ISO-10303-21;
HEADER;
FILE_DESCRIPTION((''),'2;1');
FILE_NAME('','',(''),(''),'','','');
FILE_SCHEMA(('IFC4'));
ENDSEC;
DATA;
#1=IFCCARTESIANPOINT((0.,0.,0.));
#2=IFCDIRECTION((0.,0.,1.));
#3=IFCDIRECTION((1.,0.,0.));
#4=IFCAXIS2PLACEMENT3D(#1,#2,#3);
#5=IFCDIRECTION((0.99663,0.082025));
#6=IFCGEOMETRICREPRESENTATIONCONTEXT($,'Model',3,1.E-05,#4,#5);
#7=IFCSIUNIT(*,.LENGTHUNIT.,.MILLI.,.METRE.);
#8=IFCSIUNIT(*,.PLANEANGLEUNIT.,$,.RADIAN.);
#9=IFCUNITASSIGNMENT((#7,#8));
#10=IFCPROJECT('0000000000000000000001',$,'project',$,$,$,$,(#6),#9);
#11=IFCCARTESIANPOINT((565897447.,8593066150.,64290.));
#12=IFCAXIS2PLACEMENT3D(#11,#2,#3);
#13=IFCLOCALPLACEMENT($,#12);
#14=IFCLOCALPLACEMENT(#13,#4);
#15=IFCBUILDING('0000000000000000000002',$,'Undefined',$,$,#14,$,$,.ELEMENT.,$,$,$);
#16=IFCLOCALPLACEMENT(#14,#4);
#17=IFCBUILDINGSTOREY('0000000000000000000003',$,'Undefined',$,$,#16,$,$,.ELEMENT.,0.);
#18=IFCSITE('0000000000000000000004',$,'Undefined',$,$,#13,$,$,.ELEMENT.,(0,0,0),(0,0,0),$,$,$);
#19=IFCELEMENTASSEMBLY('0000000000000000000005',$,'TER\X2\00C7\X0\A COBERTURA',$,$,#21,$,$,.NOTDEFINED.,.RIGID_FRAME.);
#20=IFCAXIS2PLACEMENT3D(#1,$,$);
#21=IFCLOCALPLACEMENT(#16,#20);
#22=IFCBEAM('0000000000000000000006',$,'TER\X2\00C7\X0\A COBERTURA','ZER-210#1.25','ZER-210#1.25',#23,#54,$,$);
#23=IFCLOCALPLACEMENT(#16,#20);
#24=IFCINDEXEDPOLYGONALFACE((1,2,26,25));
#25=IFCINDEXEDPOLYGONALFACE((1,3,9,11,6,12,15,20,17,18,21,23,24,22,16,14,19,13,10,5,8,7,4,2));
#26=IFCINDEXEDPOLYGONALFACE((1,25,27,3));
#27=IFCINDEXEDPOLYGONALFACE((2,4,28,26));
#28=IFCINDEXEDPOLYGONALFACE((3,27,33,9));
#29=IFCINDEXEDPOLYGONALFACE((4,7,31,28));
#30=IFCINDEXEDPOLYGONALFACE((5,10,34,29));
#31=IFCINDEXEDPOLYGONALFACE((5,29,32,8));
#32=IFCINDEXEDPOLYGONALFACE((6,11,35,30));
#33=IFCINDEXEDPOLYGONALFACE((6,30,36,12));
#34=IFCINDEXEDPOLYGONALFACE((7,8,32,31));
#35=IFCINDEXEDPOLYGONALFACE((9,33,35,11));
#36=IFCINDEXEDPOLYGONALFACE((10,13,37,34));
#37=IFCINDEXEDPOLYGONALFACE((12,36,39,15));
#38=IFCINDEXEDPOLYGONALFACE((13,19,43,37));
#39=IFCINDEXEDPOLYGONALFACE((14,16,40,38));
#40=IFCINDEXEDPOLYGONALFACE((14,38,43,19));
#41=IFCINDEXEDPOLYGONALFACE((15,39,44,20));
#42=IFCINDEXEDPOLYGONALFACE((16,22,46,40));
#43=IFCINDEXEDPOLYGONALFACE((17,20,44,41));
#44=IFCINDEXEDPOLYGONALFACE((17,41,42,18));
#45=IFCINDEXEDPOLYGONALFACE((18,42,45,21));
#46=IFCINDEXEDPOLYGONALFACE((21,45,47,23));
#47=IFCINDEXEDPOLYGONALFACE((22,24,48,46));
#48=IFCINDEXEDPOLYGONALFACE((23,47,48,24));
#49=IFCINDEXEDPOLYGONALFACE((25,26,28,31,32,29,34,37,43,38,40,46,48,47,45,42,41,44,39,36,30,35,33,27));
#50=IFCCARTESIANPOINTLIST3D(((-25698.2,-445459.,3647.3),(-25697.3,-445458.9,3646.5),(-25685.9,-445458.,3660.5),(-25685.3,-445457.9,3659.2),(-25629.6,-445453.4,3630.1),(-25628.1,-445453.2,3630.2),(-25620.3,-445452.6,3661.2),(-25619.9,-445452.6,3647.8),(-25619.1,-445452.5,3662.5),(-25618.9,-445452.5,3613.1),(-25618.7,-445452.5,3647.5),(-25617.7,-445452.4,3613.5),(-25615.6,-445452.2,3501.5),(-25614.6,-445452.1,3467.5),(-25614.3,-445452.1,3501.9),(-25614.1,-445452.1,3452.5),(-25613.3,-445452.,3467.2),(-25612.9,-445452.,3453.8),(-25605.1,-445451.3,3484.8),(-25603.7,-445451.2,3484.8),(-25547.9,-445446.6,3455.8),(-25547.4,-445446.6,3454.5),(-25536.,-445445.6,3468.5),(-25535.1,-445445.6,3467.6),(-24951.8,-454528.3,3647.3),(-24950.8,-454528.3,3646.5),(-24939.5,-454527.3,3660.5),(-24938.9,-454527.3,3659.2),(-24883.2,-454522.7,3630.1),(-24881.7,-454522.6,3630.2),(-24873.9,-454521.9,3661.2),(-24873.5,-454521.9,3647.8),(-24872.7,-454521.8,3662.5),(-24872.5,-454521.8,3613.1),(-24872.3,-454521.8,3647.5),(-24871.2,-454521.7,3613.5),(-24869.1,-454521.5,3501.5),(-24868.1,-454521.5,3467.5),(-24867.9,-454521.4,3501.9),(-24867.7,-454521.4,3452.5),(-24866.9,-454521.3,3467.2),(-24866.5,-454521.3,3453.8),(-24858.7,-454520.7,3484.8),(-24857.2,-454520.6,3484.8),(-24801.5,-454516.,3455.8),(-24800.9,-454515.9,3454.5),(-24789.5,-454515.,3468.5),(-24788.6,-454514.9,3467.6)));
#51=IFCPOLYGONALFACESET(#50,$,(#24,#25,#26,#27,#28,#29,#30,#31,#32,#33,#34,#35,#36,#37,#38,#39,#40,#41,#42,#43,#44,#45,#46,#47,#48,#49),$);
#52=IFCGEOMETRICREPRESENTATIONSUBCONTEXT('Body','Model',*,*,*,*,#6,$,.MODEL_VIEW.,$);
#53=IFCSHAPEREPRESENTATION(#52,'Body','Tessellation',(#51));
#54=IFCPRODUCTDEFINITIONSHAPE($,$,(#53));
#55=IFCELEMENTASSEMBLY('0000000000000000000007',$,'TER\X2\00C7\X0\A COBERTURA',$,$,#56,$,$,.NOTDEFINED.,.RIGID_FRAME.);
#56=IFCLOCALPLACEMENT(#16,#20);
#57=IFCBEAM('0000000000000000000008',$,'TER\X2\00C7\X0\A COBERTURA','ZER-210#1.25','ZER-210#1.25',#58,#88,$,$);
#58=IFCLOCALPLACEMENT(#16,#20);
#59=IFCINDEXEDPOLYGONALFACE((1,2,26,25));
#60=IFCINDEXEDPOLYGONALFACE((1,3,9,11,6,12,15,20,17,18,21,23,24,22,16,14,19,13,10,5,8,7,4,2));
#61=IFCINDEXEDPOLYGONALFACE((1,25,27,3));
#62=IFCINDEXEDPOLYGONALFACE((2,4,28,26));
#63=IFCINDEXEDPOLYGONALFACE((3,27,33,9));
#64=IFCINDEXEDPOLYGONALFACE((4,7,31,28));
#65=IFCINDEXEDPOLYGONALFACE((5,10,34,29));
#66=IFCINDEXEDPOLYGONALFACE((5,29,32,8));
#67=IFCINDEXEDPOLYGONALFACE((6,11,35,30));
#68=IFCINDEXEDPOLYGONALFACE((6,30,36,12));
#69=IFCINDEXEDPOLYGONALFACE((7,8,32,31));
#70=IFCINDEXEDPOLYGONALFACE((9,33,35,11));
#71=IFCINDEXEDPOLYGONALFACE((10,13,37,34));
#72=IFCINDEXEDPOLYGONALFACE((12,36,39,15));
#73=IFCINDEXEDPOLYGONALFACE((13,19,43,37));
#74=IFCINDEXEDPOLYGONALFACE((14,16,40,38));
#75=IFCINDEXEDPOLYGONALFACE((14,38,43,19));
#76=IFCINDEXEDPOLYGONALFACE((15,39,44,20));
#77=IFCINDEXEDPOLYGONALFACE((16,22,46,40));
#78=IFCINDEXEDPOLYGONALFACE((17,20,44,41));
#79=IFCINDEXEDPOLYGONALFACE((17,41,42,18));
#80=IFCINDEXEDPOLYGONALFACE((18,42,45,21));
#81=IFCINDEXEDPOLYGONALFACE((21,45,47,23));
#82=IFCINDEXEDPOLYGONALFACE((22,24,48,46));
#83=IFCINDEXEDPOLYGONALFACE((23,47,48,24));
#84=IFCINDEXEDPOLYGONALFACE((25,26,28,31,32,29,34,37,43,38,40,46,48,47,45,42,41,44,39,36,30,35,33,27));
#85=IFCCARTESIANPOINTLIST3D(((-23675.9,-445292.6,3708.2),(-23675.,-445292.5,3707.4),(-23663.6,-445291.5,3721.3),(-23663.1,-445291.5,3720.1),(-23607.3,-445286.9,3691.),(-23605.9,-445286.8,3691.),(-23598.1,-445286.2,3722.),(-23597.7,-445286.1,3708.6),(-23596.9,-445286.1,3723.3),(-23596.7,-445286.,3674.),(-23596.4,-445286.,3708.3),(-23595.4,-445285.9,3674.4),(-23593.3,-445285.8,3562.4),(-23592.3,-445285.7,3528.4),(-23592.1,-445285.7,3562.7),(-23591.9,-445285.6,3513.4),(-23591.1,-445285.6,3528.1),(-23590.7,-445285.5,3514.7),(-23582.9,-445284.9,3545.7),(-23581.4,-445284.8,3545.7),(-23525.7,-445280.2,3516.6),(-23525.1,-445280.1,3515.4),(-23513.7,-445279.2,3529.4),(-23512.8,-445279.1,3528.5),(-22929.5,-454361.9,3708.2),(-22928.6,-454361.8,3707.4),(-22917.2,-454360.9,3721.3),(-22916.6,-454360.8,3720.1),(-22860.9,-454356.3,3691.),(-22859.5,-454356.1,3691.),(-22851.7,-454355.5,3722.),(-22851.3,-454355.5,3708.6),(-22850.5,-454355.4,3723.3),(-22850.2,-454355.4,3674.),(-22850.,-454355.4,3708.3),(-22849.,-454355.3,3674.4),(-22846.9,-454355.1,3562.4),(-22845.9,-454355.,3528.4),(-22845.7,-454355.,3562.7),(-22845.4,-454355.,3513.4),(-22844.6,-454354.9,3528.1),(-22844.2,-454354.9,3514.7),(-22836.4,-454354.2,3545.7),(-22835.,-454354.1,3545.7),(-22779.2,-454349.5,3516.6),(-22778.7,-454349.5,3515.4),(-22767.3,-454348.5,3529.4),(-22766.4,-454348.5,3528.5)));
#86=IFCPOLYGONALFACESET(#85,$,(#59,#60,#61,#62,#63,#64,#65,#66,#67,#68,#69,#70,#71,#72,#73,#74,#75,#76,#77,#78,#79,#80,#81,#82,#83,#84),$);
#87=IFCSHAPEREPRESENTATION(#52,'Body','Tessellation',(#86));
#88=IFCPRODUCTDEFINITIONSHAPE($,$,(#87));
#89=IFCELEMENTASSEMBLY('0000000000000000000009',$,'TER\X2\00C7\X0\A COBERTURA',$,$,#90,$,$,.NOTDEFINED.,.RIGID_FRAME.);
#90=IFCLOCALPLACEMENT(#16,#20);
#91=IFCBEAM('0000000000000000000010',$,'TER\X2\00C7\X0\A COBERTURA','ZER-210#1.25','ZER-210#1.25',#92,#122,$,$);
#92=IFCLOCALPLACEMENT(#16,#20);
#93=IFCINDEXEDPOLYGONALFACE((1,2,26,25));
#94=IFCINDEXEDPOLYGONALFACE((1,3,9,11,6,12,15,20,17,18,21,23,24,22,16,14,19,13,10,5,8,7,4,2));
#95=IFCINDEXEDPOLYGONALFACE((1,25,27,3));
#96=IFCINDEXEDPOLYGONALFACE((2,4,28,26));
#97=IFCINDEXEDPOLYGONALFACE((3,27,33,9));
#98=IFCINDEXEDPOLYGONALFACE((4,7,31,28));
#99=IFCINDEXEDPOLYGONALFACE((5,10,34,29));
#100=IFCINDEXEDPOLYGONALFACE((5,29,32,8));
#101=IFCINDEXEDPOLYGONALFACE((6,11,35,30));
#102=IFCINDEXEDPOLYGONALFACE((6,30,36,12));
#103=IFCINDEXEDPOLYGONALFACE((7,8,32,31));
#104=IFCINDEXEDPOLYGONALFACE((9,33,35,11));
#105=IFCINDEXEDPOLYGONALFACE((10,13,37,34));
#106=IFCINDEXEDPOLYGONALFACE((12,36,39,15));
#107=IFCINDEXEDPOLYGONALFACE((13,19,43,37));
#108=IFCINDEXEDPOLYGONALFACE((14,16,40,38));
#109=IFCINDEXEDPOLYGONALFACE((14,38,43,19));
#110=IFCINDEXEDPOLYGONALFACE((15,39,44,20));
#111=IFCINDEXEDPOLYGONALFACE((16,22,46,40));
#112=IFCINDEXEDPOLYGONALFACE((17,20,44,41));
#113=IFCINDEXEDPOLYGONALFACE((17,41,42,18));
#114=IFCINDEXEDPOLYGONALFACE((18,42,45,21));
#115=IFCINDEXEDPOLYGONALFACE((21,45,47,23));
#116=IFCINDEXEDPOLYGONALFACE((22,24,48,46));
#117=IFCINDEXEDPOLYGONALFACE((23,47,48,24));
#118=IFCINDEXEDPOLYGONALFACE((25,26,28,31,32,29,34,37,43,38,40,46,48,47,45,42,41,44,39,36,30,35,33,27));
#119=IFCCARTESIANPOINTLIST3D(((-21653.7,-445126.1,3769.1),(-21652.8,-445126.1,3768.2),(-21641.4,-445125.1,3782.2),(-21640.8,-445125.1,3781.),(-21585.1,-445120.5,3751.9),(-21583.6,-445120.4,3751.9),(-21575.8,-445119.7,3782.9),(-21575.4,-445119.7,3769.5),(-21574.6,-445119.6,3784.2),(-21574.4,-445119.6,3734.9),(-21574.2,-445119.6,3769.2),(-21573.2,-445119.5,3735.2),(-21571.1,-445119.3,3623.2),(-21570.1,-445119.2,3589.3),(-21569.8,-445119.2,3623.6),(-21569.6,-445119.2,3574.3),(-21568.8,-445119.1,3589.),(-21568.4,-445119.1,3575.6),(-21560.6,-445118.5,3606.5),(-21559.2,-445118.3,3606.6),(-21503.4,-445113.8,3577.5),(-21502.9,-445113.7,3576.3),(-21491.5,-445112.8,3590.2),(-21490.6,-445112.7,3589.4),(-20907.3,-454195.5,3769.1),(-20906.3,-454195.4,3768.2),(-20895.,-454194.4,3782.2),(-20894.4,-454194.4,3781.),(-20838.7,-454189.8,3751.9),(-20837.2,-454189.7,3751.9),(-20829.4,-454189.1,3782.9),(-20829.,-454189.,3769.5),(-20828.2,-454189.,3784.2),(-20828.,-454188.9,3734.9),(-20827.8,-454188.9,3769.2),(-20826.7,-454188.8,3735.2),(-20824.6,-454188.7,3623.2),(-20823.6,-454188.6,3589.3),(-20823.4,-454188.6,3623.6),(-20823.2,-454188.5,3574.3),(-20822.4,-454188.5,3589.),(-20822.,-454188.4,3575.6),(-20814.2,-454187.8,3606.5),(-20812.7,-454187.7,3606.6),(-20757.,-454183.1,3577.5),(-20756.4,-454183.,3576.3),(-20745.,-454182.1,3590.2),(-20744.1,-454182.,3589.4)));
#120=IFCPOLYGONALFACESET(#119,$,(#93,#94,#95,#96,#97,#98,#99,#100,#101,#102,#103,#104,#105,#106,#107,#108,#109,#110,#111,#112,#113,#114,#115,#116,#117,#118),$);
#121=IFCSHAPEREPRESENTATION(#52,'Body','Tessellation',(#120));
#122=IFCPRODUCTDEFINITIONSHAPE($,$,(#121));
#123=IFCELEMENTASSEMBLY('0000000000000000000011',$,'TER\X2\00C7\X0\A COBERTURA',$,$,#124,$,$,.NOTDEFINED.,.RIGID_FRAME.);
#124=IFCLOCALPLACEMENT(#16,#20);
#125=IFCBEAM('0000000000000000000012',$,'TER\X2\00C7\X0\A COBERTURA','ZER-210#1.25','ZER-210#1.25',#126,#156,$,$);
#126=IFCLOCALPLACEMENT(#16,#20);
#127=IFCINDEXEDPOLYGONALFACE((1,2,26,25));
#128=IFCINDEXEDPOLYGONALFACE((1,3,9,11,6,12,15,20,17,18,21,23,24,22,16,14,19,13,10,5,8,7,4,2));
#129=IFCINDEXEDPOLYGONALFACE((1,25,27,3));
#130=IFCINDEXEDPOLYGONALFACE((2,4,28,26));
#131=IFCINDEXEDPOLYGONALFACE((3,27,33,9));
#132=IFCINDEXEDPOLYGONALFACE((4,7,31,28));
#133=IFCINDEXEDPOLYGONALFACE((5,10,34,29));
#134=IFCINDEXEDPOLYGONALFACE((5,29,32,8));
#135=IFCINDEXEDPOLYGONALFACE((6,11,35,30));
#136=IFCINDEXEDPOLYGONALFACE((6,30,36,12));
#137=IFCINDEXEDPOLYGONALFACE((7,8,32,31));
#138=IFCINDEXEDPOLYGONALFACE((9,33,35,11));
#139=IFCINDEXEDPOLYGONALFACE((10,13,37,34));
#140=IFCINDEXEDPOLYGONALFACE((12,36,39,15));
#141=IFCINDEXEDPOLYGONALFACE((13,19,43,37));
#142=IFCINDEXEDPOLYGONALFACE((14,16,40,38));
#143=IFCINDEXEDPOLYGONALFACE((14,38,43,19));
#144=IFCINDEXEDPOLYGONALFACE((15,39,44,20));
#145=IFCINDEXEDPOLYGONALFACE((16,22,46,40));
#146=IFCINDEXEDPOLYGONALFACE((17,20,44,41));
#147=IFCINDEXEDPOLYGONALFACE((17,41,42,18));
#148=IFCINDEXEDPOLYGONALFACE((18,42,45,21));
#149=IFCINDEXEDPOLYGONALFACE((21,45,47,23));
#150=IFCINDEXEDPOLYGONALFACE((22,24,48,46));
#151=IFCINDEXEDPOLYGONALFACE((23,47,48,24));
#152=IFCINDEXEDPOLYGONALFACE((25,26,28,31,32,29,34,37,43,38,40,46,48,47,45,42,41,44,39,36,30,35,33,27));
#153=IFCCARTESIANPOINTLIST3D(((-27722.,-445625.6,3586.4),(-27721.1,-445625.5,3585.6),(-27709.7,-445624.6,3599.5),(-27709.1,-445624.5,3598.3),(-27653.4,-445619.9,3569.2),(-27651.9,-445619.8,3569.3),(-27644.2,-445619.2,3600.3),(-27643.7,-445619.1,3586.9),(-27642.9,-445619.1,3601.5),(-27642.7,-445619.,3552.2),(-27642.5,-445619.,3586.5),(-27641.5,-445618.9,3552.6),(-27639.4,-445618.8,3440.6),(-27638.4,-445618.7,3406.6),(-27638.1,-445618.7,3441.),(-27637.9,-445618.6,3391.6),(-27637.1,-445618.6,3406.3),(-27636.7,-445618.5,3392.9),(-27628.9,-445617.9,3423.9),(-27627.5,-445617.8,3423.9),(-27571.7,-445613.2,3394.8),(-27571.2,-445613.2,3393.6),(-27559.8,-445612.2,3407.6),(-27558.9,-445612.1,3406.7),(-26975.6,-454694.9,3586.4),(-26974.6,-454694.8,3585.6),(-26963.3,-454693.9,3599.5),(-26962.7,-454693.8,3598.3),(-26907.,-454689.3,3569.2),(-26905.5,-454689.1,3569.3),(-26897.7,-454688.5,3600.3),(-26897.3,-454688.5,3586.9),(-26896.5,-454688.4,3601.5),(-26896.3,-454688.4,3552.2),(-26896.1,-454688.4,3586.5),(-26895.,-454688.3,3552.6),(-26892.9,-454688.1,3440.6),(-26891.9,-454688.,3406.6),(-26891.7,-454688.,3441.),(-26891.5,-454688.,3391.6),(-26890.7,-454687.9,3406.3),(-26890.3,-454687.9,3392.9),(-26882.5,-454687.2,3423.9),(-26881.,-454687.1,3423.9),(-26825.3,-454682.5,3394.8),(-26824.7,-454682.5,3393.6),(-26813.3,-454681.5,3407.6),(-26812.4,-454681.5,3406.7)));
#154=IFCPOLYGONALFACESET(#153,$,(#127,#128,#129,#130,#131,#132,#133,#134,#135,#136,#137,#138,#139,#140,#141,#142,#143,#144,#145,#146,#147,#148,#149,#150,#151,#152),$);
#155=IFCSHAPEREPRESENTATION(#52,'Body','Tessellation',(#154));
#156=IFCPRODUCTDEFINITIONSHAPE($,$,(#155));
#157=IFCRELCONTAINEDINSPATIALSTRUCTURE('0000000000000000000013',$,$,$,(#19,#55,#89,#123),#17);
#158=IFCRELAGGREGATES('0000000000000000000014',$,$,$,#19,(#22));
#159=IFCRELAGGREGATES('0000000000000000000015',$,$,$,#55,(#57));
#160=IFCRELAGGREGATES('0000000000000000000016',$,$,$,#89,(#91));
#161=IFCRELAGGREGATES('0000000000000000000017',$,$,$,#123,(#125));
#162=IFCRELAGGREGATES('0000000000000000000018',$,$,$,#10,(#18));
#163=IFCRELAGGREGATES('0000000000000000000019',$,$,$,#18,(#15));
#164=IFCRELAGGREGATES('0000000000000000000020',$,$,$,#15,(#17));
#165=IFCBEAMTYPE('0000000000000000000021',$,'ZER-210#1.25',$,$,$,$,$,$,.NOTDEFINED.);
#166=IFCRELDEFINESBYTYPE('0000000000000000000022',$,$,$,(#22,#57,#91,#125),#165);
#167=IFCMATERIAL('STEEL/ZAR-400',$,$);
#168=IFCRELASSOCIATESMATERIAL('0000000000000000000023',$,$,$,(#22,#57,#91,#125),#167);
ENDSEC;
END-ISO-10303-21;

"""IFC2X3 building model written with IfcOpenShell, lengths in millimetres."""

from ifc_helpers import new_model, si_unit, direction, frame, origin_with_axes, place, context, subcontext, project, spatial, polyline, outline, extrude, material, type_object, element, aggregate, save


model = new_model("IFC2X3")

# Units and contexts
model_context = context("Model", 3, precision=1e-05, world=origin_with_axes(), true_north=direction((0.99663, 0.082025)))
body_context = subcontext(model_context, "Body", "Model", "MODEL_VIEW")
ifc_project = project(units=[si_unit("LENGTHUNIT", "METRE", prefix="MILLI"), si_unit("PLANEANGLEUNIT", "RADIAN")], contexts=[model_context])

# Site, building, storey
site_placement = place(None, frame((565897447.0, 8593066150.0, 64290.0), z_axis=(0.0, 0.0, 1.0), x_axis=(1.0, 0.0, 0.0)))
site = spatial("IfcSite", under=ifc_project, at=site_placement, Name="Undefined", CompositionType="ELEMENT", RefLatitude=(0, 0, 0), RefLongitude=(0, 0, 0))
building_placement = place(site_placement, origin_with_axes())
building = spatial("IfcBuilding", under=site, at=building_placement, Name="Undefined", CompositionType="ELEMENT")
storey_placement = place(building_placement, origin_with_axes())
storey = spatial("IfcBuildingStorey", under=building, at=storey_placement, Name="Undefined", CompositionType="ELEMENT", Elevation=0.0)

# Element assemblies, beams
assembly_1_placement = place(storey_placement, origin_with_axes())
assembly_1 = element("IfcElementAssembly", 1, at=assembly_1_placement, inside=storey, Name="TERÇA COBERTURA", AssemblyPlace="NOTDEFINED", PredefinedType="RIGID_FRAME")
ifc_material_1 = material(Name="STEEL/ZAR-400")
beam_type_1 = type_object("IfcBeamType", Name="ZER-210#1.25", PredefinedType="NOTDEFINED")
beam_1_placement = place(assembly_1_placement, frame((-24870.2, -454521.6, 3557.5), z_axis=(-0.029885, -0.00246, 0.99955), x_axis=(-0.082025, 0.99663, 0.0)))
beam_1 = element("IfcBeam", 2, at=beam_1_placement, type_object=beam_type_1, material=ifc_material_1, Name="TERÇA COBERTURA", Description="ZER-210#1.25", ObjectType="ZER-210#1.25", context=body_context, shape_type="SweptSolid", body=[
    extrude(outline(polyline([(-65.9, 103.7), (-78.2, 91.4), (-79.1, 92.3), (-66.4, 105.0), (0.6, 105.0), (0.6, 90.0), (-9.4, 73.0), (0.6, 56.0), (0.6, -55.7), (10.8, -73.0), (0.6, -90.3), (0.6, -103.8), (65.9, -103.7), (78.2, -91.4), (79.1, -92.3), (66.4, -105.0), (-0.6, -105.0), (-0.6, -90.0), (9.4, -73.0), (-0.6, -56.0), (-0.6, 55.7), (-10.8, 73.0), (-0.6, 90.3), (-0.6, 103.8), (-65.9, 103.7)])), frame((9100.0, 0.0, 0.0), z_axis=(-1.0, 0.0, 0.0), x_axis=(0.0, -1.0, 0.0)), (0.0, 0.0, 1.0), 9100.0),
])
aggregate(assembly_1, [beam_1])
assembly_2_placement = place(storey_placement, origin_with_axes())
assembly_2 = element("IfcElementAssembly", 3, at=assembly_2_placement, inside=storey, Name="TERÇA COBERTURA", AssemblyPlace="NOTDEFINED", PredefinedType="RIGID_FRAME")
beam_2_placement = place(assembly_2_placement, frame((-22847.9, -454355.2, 3618.4), z_axis=(-0.029885, -0.00246, 0.99955), x_axis=(-0.082025, 0.99663, 0.0)))
beam_2 = element("IfcBeam", 4, at=beam_2_placement, type_object=beam_type_1, material=ifc_material_1, Name="TERÇA COBERTURA", Description="ZER-210#1.25", ObjectType="ZER-210#1.25", context=body_context, shape_type="SweptSolid", body=[
    extrude(outline(polyline([(-65.9, 103.7), (-78.2, 91.4), (-79.1, 92.3), (-66.4, 105.0), (0.6, 105.0), (0.6, 90.0), (-9.4, 73.0), (0.6, 56.0), (0.6, -55.7), (10.8, -73.0), (0.6, -90.3), (0.6, -103.8), (65.9, -103.7), (78.2, -91.4), (79.1, -92.3), (66.4, -105.0), (-0.6, -105.0), (-0.6, -90.0), (9.4, -73.0), (-0.6, -56.0), (-0.6, 55.7), (-10.8, 73.0), (-0.6, 90.3), (-0.6, 103.8), (-65.9, 103.7)])), frame((9100.0, 0.0, 0.0), z_axis=(-1.0, 0.0, 0.0), x_axis=(0.0, -1.0, 0.0)), (0.0, 0.0, 1.0), 9100.0),
])
aggregate(assembly_2, [beam_2])
assembly_3_placement = place(storey_placement, origin_with_axes())
assembly_3 = element("IfcElementAssembly", 5, at=assembly_3_placement, inside=storey, Name="TERÇA COBERTURA", AssemblyPlace="NOTDEFINED", PredefinedType="RIGID_FRAME")
beam_3_placement = place(assembly_3_placement, frame((-20825.7, -454188.7, 3679.2), z_axis=(-0.029885, -0.00246, 0.99955), x_axis=(-0.082025, 0.99663, 0.0)))
beam_3 = element("IfcBeam", 6, at=beam_3_placement, type_object=beam_type_1, material=ifc_material_1, Name="TERÇA COBERTURA", Description="ZER-210#1.25", ObjectType="ZER-210#1.25", context=body_context, shape_type="SweptSolid", body=[
    extrude(outline(polyline([(-65.9, 103.7), (-78.2, 91.4), (-79.1, 92.3), (-66.4, 105.0), (0.6, 105.0), (0.6, 90.0), (-9.4, 73.0), (0.6, 56.0), (0.6, -55.7), (10.8, -73.0), (0.6, -90.3), (0.6, -103.8), (65.9, -103.7), (78.2, -91.4), (79.1, -92.3), (66.4, -105.0), (-0.6, -105.0), (-0.6, -90.0), (9.4, -73.0), (-0.6, -56.0), (-0.6, 55.7), (-10.8, 73.0), (-0.6, 90.3), (-0.6, 103.8), (-65.9, 103.7)])), frame((9100.0, 0.0, 0.0), z_axis=(-1.0, 0.0, 0.0), x_axis=(0.0, -1.0, 0.0)), (0.0, 0.0, 1.0), 9100.0),
])
aggregate(assembly_3, [beam_3])
assembly_4_placement = place(storey_placement, origin_with_axes())
assembly_4 = element("IfcElementAssembly", 7, at=assembly_4_placement, inside=storey, Name="TERÇA COBERTURA", AssemblyPlace="NOTDEFINED", PredefinedType="RIGID_FRAME")
beam_4_placement = place(assembly_4_placement, frame((-26894.0, -454688.2, 3496.6), z_axis=(-0.029885, -0.00246, 0.99955), x_axis=(-0.082025, 0.99663, 0.0)))
beam_4 = element("IfcBeam", 8, at=beam_4_placement, type_object=beam_type_1, material=ifc_material_1, Name="TERÇA COBERTURA", Description="ZER-210#1.25", ObjectType="ZER-210#1.25", context=body_context, shape_type="SweptSolid", body=[
    extrude(outline(polyline([(-65.9, 103.7), (-78.2, 91.4), (-79.1, 92.3), (-66.4, 105.0), (0.6, 105.0), (0.6, 90.0), (-9.4, 73.0), (0.6, 56.0), (0.6, -55.7), (10.8, -73.0), (0.6, -90.3), (0.6, -103.8), (65.9, -103.7), (78.2, -91.4), (79.1, -92.3), (66.4, -105.0), (-0.6, -105.0), (-0.6, -90.0), (9.4, -73.0), (-0.6, -56.0), (-0.6, 55.7), (-10.8, 73.0), (-0.6, 90.3), (-0.6, 103.8), (-65.9, 103.7)])), frame((9100.0, 0.0, 0.0), z_axis=(-1.0, 0.0, 0.0), x_axis=(0.0, -1.0, 0.0)), (0.0, 0.0, 1.0), 9100.0),
])
aggregate(assembly_4, [beam_4])

save(model, "model.ifc")
